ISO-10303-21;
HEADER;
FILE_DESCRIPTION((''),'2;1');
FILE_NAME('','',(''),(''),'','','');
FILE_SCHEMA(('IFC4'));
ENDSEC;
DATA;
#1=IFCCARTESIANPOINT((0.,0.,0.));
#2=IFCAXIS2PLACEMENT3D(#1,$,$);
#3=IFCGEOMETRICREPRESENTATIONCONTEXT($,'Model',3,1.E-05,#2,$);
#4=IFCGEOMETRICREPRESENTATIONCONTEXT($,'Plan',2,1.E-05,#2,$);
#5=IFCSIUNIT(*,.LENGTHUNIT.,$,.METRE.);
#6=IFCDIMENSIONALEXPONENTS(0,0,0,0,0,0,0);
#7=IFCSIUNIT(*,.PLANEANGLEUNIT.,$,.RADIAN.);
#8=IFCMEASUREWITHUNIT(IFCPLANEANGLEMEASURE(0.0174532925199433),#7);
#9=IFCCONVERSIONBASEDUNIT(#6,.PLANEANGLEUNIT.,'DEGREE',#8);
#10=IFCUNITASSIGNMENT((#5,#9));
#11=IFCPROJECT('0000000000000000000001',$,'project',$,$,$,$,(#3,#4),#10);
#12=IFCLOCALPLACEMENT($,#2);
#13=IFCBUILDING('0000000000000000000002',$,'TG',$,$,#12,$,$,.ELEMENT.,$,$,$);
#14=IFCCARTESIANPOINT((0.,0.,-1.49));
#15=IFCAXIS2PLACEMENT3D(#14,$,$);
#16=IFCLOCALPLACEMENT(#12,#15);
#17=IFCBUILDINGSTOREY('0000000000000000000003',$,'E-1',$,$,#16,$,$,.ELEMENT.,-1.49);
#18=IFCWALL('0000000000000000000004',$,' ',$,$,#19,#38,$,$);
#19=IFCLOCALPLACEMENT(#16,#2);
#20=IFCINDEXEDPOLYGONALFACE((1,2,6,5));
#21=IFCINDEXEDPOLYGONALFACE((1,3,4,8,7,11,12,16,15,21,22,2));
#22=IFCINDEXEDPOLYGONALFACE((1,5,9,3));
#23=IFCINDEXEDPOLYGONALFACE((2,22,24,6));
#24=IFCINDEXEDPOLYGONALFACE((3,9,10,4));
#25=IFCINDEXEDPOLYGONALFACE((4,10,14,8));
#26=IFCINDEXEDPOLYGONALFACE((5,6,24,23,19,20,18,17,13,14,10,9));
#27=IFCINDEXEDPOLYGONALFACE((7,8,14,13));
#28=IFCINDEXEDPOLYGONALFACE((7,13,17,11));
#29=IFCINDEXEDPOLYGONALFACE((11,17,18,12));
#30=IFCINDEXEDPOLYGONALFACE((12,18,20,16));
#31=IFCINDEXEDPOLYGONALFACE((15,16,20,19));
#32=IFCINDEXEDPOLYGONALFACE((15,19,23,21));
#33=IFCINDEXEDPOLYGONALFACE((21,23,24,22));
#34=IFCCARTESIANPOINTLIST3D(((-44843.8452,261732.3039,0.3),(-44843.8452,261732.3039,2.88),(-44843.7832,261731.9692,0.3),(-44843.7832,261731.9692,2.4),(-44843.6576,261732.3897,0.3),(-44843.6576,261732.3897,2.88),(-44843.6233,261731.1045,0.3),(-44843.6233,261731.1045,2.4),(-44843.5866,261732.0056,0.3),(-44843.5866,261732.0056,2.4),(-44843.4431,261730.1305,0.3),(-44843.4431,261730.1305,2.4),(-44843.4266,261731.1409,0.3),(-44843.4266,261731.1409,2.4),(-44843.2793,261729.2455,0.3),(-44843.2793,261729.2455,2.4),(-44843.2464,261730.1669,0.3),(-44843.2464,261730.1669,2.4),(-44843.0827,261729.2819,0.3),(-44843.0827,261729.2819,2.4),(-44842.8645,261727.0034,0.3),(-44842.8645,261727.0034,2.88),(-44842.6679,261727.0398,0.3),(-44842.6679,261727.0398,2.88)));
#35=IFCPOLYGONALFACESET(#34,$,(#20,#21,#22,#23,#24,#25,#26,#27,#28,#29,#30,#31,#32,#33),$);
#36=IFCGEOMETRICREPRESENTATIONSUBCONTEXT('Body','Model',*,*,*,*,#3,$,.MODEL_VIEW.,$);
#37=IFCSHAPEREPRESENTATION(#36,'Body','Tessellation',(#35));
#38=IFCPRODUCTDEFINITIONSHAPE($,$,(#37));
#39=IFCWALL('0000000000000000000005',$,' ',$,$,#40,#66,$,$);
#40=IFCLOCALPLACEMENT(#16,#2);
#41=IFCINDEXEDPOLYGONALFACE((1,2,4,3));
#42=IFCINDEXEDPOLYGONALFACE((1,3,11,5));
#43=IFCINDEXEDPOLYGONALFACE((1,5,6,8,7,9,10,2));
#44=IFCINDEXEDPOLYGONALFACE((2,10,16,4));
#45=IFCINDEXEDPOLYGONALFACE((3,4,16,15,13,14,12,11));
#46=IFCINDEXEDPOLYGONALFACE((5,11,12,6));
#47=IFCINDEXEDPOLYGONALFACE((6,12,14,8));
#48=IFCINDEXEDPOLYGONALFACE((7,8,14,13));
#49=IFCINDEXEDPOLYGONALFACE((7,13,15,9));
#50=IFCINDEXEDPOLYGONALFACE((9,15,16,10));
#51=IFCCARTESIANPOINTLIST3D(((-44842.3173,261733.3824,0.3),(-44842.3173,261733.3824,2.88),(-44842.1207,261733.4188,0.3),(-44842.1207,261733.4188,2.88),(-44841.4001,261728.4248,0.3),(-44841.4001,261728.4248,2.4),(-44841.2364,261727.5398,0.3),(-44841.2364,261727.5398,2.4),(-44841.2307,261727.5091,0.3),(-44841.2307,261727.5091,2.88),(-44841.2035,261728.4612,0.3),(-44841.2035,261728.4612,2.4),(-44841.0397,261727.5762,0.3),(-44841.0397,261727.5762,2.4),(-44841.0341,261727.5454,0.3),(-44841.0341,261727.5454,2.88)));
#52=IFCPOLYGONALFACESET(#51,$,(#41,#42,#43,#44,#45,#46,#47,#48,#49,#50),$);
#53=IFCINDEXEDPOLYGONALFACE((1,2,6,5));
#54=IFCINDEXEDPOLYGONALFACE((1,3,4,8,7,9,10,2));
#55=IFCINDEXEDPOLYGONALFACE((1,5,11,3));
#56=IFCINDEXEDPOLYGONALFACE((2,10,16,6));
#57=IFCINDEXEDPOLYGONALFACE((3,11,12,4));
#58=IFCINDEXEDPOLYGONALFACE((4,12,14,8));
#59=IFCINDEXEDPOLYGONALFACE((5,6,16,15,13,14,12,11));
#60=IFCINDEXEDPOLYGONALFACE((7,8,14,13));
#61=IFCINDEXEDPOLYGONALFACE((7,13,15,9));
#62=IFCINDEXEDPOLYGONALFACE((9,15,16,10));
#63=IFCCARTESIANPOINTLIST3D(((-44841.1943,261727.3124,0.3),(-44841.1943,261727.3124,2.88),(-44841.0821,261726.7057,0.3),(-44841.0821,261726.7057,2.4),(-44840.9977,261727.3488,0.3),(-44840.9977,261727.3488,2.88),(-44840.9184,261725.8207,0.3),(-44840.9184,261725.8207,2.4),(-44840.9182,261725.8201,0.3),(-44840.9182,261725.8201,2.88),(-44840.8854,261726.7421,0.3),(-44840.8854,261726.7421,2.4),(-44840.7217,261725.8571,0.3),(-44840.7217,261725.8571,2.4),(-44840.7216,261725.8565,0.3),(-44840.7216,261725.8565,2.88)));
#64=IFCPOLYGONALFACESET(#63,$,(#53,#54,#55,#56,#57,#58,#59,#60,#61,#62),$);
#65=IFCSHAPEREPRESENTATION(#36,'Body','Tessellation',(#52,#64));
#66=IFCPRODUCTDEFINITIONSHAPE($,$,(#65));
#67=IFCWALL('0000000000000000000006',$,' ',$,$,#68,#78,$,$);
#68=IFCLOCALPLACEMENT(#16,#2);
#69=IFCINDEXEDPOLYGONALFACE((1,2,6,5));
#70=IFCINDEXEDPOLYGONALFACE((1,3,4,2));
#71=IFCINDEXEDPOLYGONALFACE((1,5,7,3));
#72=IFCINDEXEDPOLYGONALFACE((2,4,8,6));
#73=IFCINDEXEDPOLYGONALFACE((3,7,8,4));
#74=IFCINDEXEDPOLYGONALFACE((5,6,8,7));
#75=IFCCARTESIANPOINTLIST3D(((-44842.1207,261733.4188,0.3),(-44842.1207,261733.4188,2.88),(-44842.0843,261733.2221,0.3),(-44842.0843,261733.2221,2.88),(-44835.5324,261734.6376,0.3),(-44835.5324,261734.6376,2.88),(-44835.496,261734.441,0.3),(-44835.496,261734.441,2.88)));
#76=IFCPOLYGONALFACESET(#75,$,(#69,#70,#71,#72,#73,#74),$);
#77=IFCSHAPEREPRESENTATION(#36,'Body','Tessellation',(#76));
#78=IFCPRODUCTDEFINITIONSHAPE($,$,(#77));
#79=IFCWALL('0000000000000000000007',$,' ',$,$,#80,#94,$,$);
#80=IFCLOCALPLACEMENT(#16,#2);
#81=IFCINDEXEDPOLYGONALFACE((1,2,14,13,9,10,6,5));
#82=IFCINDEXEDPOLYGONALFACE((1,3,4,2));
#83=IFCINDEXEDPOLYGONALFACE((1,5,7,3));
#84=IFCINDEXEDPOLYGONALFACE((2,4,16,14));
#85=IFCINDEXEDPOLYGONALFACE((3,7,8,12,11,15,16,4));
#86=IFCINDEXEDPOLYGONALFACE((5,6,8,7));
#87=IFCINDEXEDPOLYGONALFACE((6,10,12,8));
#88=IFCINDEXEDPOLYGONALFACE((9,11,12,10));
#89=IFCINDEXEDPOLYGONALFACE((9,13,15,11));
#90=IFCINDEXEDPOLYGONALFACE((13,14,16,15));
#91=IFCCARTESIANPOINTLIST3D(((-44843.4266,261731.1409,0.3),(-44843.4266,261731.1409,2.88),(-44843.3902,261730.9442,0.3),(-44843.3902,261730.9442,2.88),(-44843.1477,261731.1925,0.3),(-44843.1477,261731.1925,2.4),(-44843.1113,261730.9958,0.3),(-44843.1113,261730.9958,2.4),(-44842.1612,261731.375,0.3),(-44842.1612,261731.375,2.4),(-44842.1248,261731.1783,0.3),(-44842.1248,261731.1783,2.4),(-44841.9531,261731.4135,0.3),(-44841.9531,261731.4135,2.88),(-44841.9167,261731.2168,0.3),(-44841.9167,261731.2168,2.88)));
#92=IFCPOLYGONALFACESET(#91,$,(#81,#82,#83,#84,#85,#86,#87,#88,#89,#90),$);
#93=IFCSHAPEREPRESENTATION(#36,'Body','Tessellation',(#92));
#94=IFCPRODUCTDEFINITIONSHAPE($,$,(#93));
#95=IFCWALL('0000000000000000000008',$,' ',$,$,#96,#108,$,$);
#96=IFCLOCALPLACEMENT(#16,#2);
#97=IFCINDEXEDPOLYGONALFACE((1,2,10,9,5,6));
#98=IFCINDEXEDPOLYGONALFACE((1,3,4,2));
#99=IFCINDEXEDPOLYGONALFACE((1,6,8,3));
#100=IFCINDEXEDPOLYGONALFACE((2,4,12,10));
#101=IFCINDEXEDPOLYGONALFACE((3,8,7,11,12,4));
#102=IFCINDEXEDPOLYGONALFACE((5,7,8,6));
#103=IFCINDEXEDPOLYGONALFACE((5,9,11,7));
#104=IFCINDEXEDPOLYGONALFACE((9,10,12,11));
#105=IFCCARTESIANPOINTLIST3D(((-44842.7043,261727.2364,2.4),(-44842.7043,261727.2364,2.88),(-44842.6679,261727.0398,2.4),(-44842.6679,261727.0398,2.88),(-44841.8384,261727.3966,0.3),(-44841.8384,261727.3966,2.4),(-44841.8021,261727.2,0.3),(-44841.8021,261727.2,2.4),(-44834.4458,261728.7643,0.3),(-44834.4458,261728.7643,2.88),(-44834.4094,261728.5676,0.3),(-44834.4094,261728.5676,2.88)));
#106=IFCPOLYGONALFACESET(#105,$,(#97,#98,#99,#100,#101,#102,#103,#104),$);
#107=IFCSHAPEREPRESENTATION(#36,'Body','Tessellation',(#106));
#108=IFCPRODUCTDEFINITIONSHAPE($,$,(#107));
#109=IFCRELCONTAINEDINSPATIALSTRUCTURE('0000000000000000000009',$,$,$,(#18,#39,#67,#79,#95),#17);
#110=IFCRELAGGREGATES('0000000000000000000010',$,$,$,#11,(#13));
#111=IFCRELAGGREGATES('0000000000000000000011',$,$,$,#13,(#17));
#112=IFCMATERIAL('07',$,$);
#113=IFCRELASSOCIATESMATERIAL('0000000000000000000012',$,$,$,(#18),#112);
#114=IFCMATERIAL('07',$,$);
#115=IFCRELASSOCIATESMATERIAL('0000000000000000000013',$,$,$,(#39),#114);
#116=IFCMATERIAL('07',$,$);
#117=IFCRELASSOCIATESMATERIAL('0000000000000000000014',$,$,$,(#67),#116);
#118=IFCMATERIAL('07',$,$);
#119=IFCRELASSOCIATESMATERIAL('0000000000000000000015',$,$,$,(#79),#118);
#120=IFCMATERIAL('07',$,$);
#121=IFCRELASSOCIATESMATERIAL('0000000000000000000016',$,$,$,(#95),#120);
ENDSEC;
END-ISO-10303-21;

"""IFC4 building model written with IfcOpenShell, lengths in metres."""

from ifc_helpers import new_model, entity, si_unit, converted_unit, frame, frame_2d, origin, origin_with_axes, place, context, subcontext, project, spatial, polyline, rectangle, outline, extrude, material, element, save


model = new_model("IFC4")

# Units and contexts
model_context = context("Model", 3, precision=1e-05, world=origin())
plan_context = context("Plan", 2, precision=1e-05, world=origin())
body_context = subcontext(model_context, "Body", "Model", "MODEL_VIEW")
ifc_project = project(units=[si_unit("LENGTHUNIT", "METRE"), converted_unit("PLANEANGLEUNIT", "DEGREE", entity("IfcPlaneAngleMeasure", 0.0174532925199433), si_unit("PLANEANGLEUNIT", "RADIAN"), dimensions=[0, 0, 0, 0, 0, 0, 0])], contexts=[model_context, plan_context])

# Building, storey
building_placement = place(None, origin())
building = spatial("IfcBuilding", under=ifc_project, at=building_placement, Name="TG", CompositionType="ELEMENT")
storey_placement = place(building_placement, frame((0.0, 0.0, -1.49)))
storey = spatial("IfcBuildingStorey", under=building, at=storey_placement, Name="E-1", CompositionType="ELEMENT", Elevation=-1.49)

# Walls, openings
ifc_material_1 = material(Name="07")
wall_1_placement = place(storey_placement, frame((-44842.6679, 261727.0398, 0.3), z_axis=(0.0, 0.0, 1.0), x_axis=(-0.18192, 0.983313, 0.0)))
wall_1 = element("IfcWall", 1, at=wall_1_placement, inside=storey, material=ifc_material_1, Name=" ", context=body_context, shape_type="SweptSolid", body=[
    extrude(outline(polyline([(-0.1784, -1.1643), (5.2623, -1.1643), (5.2121, -0.9643), (-0.1784, -0.9643), (-0.1784, -1.1643)])), frame((0.1784, 1.1643, 0.0), z_axis=(0.0, 0.0, 1.0), x_axis=(1.0, 0.0, 0.0)), (0.0, 0.0, 1.0), 2.58),
])
opening_1_placement = place(wall_1_placement, frame((5.0501, 0.2, 0.0), z_axis=(0.0, -1.0, 0.0), x_axis=(0.0, 0.0, 1.0)))
element("IfcOpeningElement", 2, at=opening_1_placement, cuts=wall_1, ObjectType="Opening", context=body_context, shape_type="SweptSolid", body=[
    extrude(outline(polyline([(0.0, 0.8794), (2.1, 0.8794), (2.1, 0.0), (0.0, 0.0), (0.0, 0.8794)])), origin_with_axes(), (0.0, 0.0, 1.0), 0.2),
])
opening_2_placement = place(wall_1_placement, frame((2.2802, 0.0, 0.0), z_axis=(0.0, 1.0, 0.0), x_axis=(0.0, 0.0, 1.0)))
element("IfcOpeningElement", 3, at=opening_2_placement, cuts=wall_1, ObjectType="Opening", context=body_context, shape_type="SweptSolid", body=[
    extrude(outline(polyline([(0.0, 0.9), (2.1, 0.9), (2.1, 0.0), (0.0, 0.0), (0.0, 0.9)])), origin_with_axes(), (0.0, 0.0, 1.0), 0.2),
])
ifc_material_2 = material(Name="07")
wall_2_placement = place(storey_placement, frame((-44842.3173, 261733.3824, 0.3), z_axis=(0.0, 0.0, 1.0), x_axis=(0.18192, -0.983313, 0.0)))
wall_2 = element("IfcWall", 4, at=wall_2_placement, inside=storey, material=ifc_material_2, Name=" ", context=body_context, shape_type="SweptSolid", body=[
    extrude(rectangle(XDim=5.973, YDim=0.2, at=frame_2d((2.9865, 0.1), x_axis=(1.0, 0.0))), origin_with_axes(), (0.0, 0.0, 1.0), 2.58),
    extrude(rectangle(XDim=0.2, YDim=1.5176, at=frame_2d((-0.7588, 0.1), x_axis=(0.0, 1.0))), frame((7.6906, 0.0, 0.0), z_axis=(0.0, 0.0, 1.0), x_axis=(1.0, 0.0, 0.0)), (0.0, 0.0, 1.0), 2.58),
])
opening_3_placement = place(wall_2_placement, frame((5.9417, 0.2, 0.0), z_axis=(0.0, -1.0, 0.0), x_axis=(0.0, 0.0, 1.0)))
element("IfcOpeningElement", 5, at=opening_3_placement, cuts=wall_2, ObjectType="Opening", context=body_context, shape_type="SweptSolid", body=[
    extrude(outline(polyline([(0.0, 0.9), (2.1, 0.9), (2.1, 0.0), (0.0, 0.0), (0.0, 0.9)])), origin_with_axes(), (0.0, 0.0, 1.0), 0.2),
])
opening_4_placement = place(wall_2_placement, frame((7.69, 0.2, 0.0), z_axis=(0.0, -1.0, 0.0), x_axis=(0.0, 0.0, 1.0)))
element("IfcOpeningElement", 6, at=opening_4_placement, cuts=wall_2, ObjectType="Opening", context=body_context, shape_type="SweptSolid", body=[
    extrude(outline(polyline([(0.0, 0.9), (2.1, 0.9), (2.1, 0.0), (0.0, 0.0), (0.0, 0.9)])), origin_with_axes(), (0.0, 0.0, 1.0), 0.2),
])

# Wall
ifc_material_3 = material(Name="07")
wall_3_placement = place(storey_placement, frame((-44835.5324, 261734.6376, 0.3), z_axis=(0.0, 0.0, 1.0), x_axis=(-0.983313, -0.18192, 0.0)))
element("IfcWall", 7, at=wall_3_placement, inside=storey, material=ifc_material_3, Name=" ", context=body_context, shape_type="SweptSolid", body=[
    extrude(rectangle(XDim=6.7001, YDim=0.2, at=frame_2d((3.35, 0.1), x_axis=(1.0, 0.0))), origin_with_axes(), (0.0, 0.0, 1.0), 2.58),
])

# Walls, openings
ifc_material_4 = material(Name="07")
wall_4_placement = place(storey_placement, frame((-44841.9531, 261731.4135, 0.3), z_axis=(0.0, 0.0, 1.0), x_axis=(-0.983313, -0.18192, 0.0)))
wall_4 = element("IfcWall", 8, at=wall_4_placement, inside=storey, material=ifc_material_4, Name=" ", context=body_context, shape_type="SweptSolid", body=[
    extrude(rectangle(XDim=1.4985, YDim=0.2, at=frame_2d((0.7493, 0.1), x_axis=(1.0, 0.0))), origin_with_axes(), (0.0, 0.0, 1.0), 2.58),
])
opening_5_placement = place(wall_4_placement, frame((0.2117, 0.0, 0.0), z_axis=(0.0, 1.0, 0.0), x_axis=(0.0, 0.0, 1.0)))
element("IfcOpeningElement", 9, at=opening_5_placement, cuts=wall_4, ObjectType="Opening", context=body_context, shape_type="SweptSolid", body=[
    extrude(outline(polyline([(0.0, 1.0033), (2.1, 1.0033), (2.1, 0.0), (0.0, 0.0), (0.0, 1.0033)])), origin_with_axes(), (0.0, 0.0, 1.0), 0.2),
])
ifc_material_5 = material(Name="07")
wall_5_placement = place(storey_placement, frame((-44834.4458, 261728.7643, 0.3), z_axis=(0.0, 0.0, 1.0), x_axis=(-0.983313, -0.18192, 0.0)))
wall_5 = element("IfcWall", 10, at=wall_5_placement, inside=storey, material=ifc_material_5, Name=" ", context=body_context, shape_type="SweptSolid", body=[
    extrude(rectangle(XDim=8.3986, YDim=0.2, at=frame_2d((4.1993, 0.1), x_axis=(1.0, 0.0))), origin_with_axes(), (0.0, 0.0, 1.0), 2.58),
])
opening_6_placement = place(wall_5_placement, frame((8.3986, 0.2, 0.0), z_axis=(0.0, -1.0, 0.0), x_axis=(0.0, 0.0, 1.0)))
element("IfcOpeningElement", 11, at=opening_6_placement, cuts=wall_5, ObjectType="Opening", context=body_context, shape_type="SweptSolid", body=[
    extrude(outline(polyline([(0.0, 0.8805), (0.0, 0.0), (2.1, 0.0), (2.1, 0.8805), (0.0, 0.8805)])), origin_with_axes(), (0.0, 0.0, 1.0), 0.2),
])

save(model, "model.ifc")
